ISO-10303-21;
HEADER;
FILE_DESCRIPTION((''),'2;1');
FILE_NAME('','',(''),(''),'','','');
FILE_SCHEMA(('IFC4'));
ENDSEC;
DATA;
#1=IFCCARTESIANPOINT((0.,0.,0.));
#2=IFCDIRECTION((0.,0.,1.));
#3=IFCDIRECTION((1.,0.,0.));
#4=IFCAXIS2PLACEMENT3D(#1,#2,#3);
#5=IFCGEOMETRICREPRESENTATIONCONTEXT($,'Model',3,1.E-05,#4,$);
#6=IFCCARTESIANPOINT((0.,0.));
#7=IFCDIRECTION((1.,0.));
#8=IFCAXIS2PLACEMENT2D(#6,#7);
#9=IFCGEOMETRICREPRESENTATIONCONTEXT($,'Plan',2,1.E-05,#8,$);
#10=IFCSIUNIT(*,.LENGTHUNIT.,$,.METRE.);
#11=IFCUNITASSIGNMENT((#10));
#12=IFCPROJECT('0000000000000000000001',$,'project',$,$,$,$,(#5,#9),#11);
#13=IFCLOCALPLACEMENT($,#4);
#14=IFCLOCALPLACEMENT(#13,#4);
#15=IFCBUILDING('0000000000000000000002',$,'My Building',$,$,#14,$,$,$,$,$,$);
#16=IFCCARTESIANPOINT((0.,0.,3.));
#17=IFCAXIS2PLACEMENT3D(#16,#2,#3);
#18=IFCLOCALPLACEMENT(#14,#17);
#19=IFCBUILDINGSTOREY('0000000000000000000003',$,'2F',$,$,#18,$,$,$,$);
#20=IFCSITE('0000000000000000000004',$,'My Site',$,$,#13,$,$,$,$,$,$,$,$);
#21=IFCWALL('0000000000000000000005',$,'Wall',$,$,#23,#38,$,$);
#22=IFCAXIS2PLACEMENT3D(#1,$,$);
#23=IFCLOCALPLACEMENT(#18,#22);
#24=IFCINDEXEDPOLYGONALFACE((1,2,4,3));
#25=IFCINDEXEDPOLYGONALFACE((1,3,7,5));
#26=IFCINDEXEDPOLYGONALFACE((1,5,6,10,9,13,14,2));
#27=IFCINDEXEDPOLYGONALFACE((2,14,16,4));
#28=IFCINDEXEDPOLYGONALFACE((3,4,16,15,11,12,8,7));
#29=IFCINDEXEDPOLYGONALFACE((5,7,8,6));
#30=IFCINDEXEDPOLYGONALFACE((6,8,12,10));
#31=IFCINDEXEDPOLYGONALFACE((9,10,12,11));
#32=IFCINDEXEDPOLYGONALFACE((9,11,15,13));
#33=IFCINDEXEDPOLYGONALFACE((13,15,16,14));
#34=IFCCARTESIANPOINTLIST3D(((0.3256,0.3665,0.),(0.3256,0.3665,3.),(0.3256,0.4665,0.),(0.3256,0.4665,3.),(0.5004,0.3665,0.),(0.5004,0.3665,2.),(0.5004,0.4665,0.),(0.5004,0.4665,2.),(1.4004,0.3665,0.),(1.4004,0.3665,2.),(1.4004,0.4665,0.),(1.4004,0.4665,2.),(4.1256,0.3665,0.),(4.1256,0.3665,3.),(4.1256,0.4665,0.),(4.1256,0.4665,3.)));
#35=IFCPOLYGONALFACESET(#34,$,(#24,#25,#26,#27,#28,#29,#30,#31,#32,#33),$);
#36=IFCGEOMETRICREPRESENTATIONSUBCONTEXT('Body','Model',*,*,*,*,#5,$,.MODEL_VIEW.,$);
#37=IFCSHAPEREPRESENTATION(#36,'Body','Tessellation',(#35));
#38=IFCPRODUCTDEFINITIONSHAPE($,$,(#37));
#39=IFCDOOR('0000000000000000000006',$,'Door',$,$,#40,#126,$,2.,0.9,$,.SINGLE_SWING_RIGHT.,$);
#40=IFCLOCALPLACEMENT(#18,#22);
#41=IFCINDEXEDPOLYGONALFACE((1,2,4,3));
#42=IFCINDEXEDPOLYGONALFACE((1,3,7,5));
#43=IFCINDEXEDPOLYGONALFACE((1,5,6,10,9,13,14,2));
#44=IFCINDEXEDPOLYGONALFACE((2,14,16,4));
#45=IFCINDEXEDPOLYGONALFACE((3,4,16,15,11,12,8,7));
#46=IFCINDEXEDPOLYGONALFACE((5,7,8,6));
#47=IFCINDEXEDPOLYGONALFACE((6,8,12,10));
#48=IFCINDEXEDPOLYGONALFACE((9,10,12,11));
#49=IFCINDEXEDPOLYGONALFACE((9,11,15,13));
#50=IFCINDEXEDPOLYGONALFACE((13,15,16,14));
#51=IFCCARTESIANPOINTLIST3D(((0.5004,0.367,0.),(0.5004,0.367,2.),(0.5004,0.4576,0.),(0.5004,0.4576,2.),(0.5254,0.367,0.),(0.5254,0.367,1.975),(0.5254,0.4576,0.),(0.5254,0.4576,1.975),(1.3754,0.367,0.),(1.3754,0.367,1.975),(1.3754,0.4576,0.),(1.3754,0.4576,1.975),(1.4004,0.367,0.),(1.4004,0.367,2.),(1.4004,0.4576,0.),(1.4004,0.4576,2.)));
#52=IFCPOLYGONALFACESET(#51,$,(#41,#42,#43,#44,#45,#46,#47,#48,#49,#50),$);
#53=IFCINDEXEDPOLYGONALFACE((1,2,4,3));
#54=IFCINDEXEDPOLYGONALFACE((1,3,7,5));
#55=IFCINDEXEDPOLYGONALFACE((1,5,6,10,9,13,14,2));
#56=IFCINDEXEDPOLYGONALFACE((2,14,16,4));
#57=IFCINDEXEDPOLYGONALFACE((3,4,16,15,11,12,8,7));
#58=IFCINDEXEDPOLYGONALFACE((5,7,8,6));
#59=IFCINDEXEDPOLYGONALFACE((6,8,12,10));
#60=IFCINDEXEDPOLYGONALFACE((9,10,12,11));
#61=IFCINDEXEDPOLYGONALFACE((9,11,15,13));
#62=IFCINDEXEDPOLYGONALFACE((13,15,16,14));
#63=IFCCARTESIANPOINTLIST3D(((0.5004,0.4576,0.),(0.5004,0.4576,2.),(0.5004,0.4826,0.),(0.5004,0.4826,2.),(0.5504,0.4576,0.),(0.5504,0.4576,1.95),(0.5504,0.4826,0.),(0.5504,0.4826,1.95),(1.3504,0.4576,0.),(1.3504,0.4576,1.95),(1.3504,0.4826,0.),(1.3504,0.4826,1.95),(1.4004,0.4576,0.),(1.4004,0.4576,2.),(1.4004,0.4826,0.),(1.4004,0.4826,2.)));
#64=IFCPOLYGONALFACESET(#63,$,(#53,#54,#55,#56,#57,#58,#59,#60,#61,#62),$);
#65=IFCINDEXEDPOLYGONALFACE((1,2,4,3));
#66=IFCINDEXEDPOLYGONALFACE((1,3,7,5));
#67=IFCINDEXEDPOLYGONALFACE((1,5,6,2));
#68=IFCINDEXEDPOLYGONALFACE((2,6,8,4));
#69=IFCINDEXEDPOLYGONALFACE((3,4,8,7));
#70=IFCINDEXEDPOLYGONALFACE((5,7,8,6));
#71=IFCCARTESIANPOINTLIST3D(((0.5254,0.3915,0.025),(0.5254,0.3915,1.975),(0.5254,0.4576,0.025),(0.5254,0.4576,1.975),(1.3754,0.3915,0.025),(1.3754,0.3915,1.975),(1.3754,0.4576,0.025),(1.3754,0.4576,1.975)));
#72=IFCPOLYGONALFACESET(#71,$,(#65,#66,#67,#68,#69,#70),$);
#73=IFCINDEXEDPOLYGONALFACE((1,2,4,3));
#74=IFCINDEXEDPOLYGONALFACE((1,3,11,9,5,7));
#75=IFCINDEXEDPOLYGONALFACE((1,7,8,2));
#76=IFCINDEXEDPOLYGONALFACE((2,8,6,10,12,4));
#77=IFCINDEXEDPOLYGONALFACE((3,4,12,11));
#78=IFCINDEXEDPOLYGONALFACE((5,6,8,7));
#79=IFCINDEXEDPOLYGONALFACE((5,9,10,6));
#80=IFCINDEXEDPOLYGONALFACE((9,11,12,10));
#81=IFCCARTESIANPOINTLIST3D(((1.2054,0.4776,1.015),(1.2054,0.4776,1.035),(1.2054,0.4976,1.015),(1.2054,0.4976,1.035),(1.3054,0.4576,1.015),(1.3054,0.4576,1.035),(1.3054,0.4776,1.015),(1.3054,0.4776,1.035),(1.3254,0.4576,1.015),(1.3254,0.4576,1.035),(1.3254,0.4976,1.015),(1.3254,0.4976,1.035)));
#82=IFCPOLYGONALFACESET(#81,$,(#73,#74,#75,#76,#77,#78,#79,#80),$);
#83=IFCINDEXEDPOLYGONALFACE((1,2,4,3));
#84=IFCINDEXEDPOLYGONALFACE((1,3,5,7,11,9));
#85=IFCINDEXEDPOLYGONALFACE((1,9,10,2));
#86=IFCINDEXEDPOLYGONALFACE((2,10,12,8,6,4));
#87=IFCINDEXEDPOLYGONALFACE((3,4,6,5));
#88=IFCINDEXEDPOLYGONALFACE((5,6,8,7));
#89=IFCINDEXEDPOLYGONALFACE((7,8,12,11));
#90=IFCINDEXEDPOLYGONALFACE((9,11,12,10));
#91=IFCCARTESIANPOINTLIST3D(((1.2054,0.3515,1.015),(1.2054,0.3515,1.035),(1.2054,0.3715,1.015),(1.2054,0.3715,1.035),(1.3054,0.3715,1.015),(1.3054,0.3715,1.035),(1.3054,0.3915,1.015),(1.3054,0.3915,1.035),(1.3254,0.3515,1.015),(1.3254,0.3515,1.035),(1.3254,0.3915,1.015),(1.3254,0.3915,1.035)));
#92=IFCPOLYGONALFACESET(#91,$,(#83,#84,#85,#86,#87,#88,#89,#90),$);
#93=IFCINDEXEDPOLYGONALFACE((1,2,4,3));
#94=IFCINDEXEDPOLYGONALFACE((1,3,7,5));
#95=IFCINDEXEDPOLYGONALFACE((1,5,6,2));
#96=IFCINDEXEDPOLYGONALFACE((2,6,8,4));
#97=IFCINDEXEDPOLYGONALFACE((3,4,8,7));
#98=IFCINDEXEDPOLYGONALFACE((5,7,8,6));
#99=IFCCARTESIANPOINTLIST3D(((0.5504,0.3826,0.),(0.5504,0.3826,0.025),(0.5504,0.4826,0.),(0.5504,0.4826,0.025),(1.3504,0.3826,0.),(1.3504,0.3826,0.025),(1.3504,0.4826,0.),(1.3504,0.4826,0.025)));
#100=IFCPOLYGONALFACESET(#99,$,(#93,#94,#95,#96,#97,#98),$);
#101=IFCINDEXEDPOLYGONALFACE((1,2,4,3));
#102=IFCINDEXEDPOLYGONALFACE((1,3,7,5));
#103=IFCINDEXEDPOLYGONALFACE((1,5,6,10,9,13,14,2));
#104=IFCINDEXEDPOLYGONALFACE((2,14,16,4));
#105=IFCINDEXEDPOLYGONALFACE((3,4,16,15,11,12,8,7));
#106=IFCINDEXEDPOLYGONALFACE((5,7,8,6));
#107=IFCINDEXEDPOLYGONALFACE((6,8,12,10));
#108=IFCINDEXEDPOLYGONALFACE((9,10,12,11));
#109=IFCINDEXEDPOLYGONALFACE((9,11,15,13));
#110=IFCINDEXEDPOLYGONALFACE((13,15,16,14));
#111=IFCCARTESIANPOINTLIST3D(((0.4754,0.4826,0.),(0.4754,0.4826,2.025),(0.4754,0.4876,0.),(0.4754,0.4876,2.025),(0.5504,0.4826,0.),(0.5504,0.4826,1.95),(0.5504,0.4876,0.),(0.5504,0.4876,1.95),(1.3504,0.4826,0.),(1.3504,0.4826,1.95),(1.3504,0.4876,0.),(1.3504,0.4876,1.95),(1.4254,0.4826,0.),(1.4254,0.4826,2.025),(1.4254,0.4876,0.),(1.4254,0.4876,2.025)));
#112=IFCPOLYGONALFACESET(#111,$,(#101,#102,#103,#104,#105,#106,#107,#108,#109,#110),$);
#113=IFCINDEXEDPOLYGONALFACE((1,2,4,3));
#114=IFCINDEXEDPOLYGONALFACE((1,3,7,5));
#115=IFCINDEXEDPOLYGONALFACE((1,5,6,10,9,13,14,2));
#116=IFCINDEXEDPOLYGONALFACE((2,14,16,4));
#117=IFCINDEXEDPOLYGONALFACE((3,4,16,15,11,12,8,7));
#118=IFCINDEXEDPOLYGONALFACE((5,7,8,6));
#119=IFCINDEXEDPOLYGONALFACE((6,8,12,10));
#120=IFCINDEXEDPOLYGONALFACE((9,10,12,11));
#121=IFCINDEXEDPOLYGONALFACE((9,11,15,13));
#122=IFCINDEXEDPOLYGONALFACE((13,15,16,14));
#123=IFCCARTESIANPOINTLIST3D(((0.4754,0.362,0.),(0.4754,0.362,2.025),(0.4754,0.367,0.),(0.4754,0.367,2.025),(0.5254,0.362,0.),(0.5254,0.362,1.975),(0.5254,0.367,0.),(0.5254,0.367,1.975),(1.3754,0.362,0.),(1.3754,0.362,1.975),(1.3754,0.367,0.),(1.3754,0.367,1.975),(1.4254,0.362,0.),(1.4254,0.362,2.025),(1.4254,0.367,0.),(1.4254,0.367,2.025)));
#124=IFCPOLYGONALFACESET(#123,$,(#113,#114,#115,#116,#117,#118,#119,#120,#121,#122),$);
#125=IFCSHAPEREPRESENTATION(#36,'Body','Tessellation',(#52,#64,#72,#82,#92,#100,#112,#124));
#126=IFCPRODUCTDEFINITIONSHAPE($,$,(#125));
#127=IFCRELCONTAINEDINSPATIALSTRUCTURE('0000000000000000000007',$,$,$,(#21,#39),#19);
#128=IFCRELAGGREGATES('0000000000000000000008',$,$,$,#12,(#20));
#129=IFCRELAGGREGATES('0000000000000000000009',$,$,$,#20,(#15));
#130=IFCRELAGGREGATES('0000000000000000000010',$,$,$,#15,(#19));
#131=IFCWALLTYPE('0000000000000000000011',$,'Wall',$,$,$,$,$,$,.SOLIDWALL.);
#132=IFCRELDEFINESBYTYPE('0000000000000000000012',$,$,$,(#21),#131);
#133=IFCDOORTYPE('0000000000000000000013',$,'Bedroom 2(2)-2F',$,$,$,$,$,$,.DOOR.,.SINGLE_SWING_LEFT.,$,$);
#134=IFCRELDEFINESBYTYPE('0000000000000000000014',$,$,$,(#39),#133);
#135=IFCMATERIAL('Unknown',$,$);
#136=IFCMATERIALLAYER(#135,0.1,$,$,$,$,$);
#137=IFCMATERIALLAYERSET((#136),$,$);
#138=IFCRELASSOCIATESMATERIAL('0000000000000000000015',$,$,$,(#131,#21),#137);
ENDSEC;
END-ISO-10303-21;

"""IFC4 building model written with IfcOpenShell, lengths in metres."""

from ifc_helpers import new_model, entity, si_unit, frame, origin_with_axes, origin_2d_with_axis, place, context, subcontext, project, spatial, line, indexed_curve, outline, extrude, shape, source, transform, mapped, material, layer, layer_set, layer_usage, type_object, type_shapes, element, fill, save


model = new_model("IFC4")

# Units and contexts
model_context = context("Model", 3, precision=1e-05, world=origin_with_axes())
plan_context = context("Plan", 2, precision=1e-05, world=origin_2d_with_axis())
body_context_1 = subcontext(model_context, "Body", "Model", "MODEL_VIEW")
body_context_2 = subcontext(plan_context, "Body", "Plan", "PLAN_VIEW")
ifc_project = project(units=[si_unit("LENGTHUNIT", "METRE")], contexts=[model_context, plan_context])

# Site, building, storey
site_placement = place(None, origin_with_axes())
site = spatial("IfcSite", under=ifc_project, at=site_placement, Name="My Site")
building_placement = place(site_placement, origin_with_axes())
building = spatial("IfcBuilding", under=site, at=building_placement, Name="My Building")
storey_placement = place(building_placement, frame((0.0, 0.0, 3.0), z_axis=(0.0, 0.0, 1.0), x_axis=(1.0, 0.0, 0.0)))
storey = spatial("IfcBuildingStorey", under=building, at=storey_placement, Name="2F")

# Shared definitions
ifc_material = material(Name="Unknown")
ifc_layer = layer(ifc_material, 0.1)
ifc_layer_set = layer_set([ifc_layer])
wall_type = type_object("IfcWallType", Name="Wall", PredefinedType="SOLIDWALL", material=ifc_layer_set)

# Wall, opening, door
ifc_layer_usage_1 = layer_usage(ifc_layer_set, "AXIS2", "POSITIVE", 0.0)
wall_1_placement = place(storey_placement, frame((4.1256, 0.4665, 0.0), z_axis=(0.0, 0.0, 1.0), x_axis=(-1.0, 0.0, 0.0)))
wall_1 = element("IfcWall", 1, at=wall_1_placement, inside=storey, type_object=wall_type, material=ifc_layer_usage_1, Name="Wall", context=body_context_1, shape_type="SweptSolid", body=[
    extrude(outline(indexed_curve([(0.0, 0.0), (0.0, 0.1), (3.8, 0.1), (3.8, 0.0)], segments=[line(1, 2, 3, 4, 1)])), origin_with_axes(), (0.0, 0.0, 1.0), 3.0),
])
shared_shape_1 = source(origin_with_axes(), body_context_1, "Body", "SweptSolid", [
    extrude(outline(indexed_curve([(0.0, 0.0), (0.9, 0.0), (0.9, 2.0), (0.0, 2.0)], segments=[line(1, 2, 3, 4, 1)])), frame((0.0, -0.6, 0.0), z_axis=(0.0, -1.0, 0.0), x_axis=(1.0, 0.0, 0.0)), (0.0, 0.0, -1.0), 1.2),
])
opening_1_placement = place(wall_1_placement, frame((2.7252, -0.0161, 0.0), z_axis=(0.0, 0.0, 1.0), x_axis=(1.0, 0.0, 0.0)))
opening_1 = element("IfcOpeningElement", 2, at=opening_1_placement, cuts=wall_1, PredefinedType="OPENING", context=body_context_1, shape_type="MappedRepresentation", body=[
    mapped(shared_shape_1, transform((0.0, 0.0, 0.0), x_axis=(1.0, 0.0, 0.0), y_axis=(0.0, 1.0, 0.0), z_axis=(0.0, 0.0, 1.0), scale=1.0)),
])
door_type_1 = type_object("IfcDoorType", Name="Bedroom 2(2)-2F", OperationType="SINGLE_SWING_LEFT", PredefinedType="DOOR")
shared_shape_2 = source(origin_with_axes(), body_context_1, "Body", "SweptSolid", [
    extrude(outline(indexed_curve([(0.0, 0.0), (0.0, 2.0), (0.9, 2.0), (0.9, 0.0), (0.875, 0.0), (0.875, 1.975), (0.025, 1.975), (0.025, 0.0)], segments=[line(1, 2, 3, 4, 5, 6, 7, 8, 1)])), frame((0.0, 0.025, 0.0), z_axis=(0.0, -1.0, 0.0), x_axis=(1.0, 0.0, 0.0)), (0.0, 0.0, -1.0), 0.0906),
    extrude(outline(indexed_curve([(0.0, 0.0), (0.0, 2.0), (0.9, 2.0), (0.9, 0.0), (0.85, 0.0), (0.85, 1.95), (0.05, 1.95), (0.05, 0.0)], segments=[line(1, 2, 3, 4, 5, 6, 7, 8, 1)])), frame((0.0, 0.0, 0.0), z_axis=(0.0, -1.0, 0.0), x_axis=(1.0, 0.0, 0.0)), (0.0, 0.0, -1.0), 0.025),
    extrude(outline(indexed_curve([(0.0, 0.0), (0.85, 0.0), (0.85, 0.0661), (0.0, 0.0661)], segments=[line(1, 2, 3, 4, 1)])), frame((0.025, 0.025, 0.025), z_axis=(0.0, 0.0, 1.0), x_axis=(1.0, 0.0, 0.0)), (0.0, 0.0, 1.0), 1.95),
    extrude(outline(indexed_curve([(0.0, 0.0), (0.0, -0.04), (0.12, -0.04), (0.12, -0.02), (0.02, -0.02), (0.02, 0.0)], segments=[line(1, 2, 3, 4, 5, 6, 1)])), frame((0.075, 0.025, 1.015), z_axis=(0.0, 0.0, 1.0), x_axis=(1.0, 0.0, 0.0)), (0.0, 0.0, 1.0), 0.02),
    extrude(outline(indexed_curve([(0.0, 0.0), (0.0, 0.04), (0.12, 0.04), (0.12, 0.02), (0.02, 0.02), (0.02, 0.0)], segments=[line(1, 2, 3, 4, 5, 6, 1)])), frame((0.075, 0.0911, 1.015), z_axis=(0.0, 0.0, 1.0), x_axis=(1.0, 0.0, 0.0)), (0.0, 0.0, 1.0), 0.02),
    extrude(outline(indexed_curve([(0.0, 0.0), (0.8, 0.0), (0.8, 0.1), (0.0, 0.1)], segments=[line(1, 2, 3, 4, 1)])), frame((0.05, 0.0, 0.0), z_axis=(0.0, 0.0, 1.0), x_axis=(1.0, 0.0, 0.0)), (0.0, 0.0, 1.0), 0.025),
    extrude(outline(indexed_curve([(0.0, 0.0), (0.0, 2.025), (0.95, 2.025), (0.95, 0.0), (0.875, 0.0), (0.875, 1.95), (0.075, 1.95), (0.075, 0.0)], segments=[line(1, 2, 3, 4, 5, 6, 7, 8, 1)])), frame((-0.025, -0.005, 0.0), z_axis=(0.0, -1.0, 0.0), x_axis=(1.0, 0.0, 0.0)), (0.0, 0.0, -1.0), 0.005),
    extrude(outline(indexed_curve([(0.0, 0.0), (0.0, 2.025), (0.95, 2.025), (0.95, 0.0), (0.9, 0.0), (0.9, 1.975), (0.05, 1.975), (0.05, 0.0)], segments=[line(1, 2, 3, 4, 5, 6, 7, 8, 1)])), frame((-0.025, 0.1156, 0.0), z_axis=(0.0, -1.0, 0.0), x_axis=(1.0, 0.0, 0.0)), (0.0, 0.0, -1.0), 0.005),
])
shared_shape_3 = source(origin_with_axes(), body_context_2, "Body", "Curve2D", [
    entity("IfcIndexedPolyCurve", entity("IfcCartesianPointList2D", [[0.0, 0.0], [0.0, 0.1156], [0.025, 0.1156], [0.025, 0.025], [0.05, 0.025], [0.05, 0.0]]), [entity("IfcLineIndex", [1, 2, 3, 4, 5, 6, 1])]),
    entity("IfcIndexedPolyCurve", entity("IfcCartesianPointList2D", [[0.9, 0.0], [0.9, 0.1156], [0.875, 0.1156], [0.875, 0.025], [0.85, 0.025], [0.85, 0.0]]), [entity("IfcLineIndex", [1, 2, 3, 4, 5, 6, 1])]),
    entity("IfcTrimmedCurve", entity("IfcEllipse", entity("IfcAxis2Placement2D", entity("IfcCartesianPoint", [0.8089, 0.1156]), entity("IfcDirection", [1.0, 0.0])), 0.7839, 0.85), [entity("IfcCartesianPoint", [0.8089, 0.9656])], [entity("IfcCartesianPoint", [0.025, 0.1156])], True, "CARTESIAN"),
    entity("IfcIndexedPolyCurve", entity("IfcCartesianPointList2D", [[0.875, 0.1156], [0.8089, 0.1156], [0.8089, 0.9656], [0.875, 0.9656]]), [entity("IfcLineIndex", [1, 2, 3, 4, 1])]),
])
type_shapes(door_type_1, [shared_shape_2, shared_shape_3])
door_1_placement = place(opening_1_placement, frame((0.0, 0.0, 0.0), z_axis=(0.0, 0.0, 1.0), x_axis=(1.0, 0.0, 0.0)))
door_1 = element("IfcDoor", 3, at=door_1_placement, inside=storey, type_object=door_type_1, Name="Door", OperationType="SINGLE_SWING_RIGHT", OverallHeight=2.0, OverallWidth=0.9, shapes=[
    shape(body_context_1, "Body", "MappedRepresentation", [mapped(shared_shape_2, transform((0.0, 0.0, 0.0), x_axis=(1.0, 0.0, 0.0), y_axis=(0.0, 1.0, 0.0), z_axis=(0.0, 0.0, 1.0), scale=1.0))]),
    shape(body_context_2, "Body", "MappedRepresentation", [mapped(shared_shape_3, transform((0.0, 0.0, 0.0), x_axis=(1.0, 0.0, 0.0), y_axis=(0.0, 1.0, 0.0), z_axis=(0.0, 0.0, 1.0), scale=1.0))]),
])
fill(opening_1, door_1)

save(model, "model.ifc")
